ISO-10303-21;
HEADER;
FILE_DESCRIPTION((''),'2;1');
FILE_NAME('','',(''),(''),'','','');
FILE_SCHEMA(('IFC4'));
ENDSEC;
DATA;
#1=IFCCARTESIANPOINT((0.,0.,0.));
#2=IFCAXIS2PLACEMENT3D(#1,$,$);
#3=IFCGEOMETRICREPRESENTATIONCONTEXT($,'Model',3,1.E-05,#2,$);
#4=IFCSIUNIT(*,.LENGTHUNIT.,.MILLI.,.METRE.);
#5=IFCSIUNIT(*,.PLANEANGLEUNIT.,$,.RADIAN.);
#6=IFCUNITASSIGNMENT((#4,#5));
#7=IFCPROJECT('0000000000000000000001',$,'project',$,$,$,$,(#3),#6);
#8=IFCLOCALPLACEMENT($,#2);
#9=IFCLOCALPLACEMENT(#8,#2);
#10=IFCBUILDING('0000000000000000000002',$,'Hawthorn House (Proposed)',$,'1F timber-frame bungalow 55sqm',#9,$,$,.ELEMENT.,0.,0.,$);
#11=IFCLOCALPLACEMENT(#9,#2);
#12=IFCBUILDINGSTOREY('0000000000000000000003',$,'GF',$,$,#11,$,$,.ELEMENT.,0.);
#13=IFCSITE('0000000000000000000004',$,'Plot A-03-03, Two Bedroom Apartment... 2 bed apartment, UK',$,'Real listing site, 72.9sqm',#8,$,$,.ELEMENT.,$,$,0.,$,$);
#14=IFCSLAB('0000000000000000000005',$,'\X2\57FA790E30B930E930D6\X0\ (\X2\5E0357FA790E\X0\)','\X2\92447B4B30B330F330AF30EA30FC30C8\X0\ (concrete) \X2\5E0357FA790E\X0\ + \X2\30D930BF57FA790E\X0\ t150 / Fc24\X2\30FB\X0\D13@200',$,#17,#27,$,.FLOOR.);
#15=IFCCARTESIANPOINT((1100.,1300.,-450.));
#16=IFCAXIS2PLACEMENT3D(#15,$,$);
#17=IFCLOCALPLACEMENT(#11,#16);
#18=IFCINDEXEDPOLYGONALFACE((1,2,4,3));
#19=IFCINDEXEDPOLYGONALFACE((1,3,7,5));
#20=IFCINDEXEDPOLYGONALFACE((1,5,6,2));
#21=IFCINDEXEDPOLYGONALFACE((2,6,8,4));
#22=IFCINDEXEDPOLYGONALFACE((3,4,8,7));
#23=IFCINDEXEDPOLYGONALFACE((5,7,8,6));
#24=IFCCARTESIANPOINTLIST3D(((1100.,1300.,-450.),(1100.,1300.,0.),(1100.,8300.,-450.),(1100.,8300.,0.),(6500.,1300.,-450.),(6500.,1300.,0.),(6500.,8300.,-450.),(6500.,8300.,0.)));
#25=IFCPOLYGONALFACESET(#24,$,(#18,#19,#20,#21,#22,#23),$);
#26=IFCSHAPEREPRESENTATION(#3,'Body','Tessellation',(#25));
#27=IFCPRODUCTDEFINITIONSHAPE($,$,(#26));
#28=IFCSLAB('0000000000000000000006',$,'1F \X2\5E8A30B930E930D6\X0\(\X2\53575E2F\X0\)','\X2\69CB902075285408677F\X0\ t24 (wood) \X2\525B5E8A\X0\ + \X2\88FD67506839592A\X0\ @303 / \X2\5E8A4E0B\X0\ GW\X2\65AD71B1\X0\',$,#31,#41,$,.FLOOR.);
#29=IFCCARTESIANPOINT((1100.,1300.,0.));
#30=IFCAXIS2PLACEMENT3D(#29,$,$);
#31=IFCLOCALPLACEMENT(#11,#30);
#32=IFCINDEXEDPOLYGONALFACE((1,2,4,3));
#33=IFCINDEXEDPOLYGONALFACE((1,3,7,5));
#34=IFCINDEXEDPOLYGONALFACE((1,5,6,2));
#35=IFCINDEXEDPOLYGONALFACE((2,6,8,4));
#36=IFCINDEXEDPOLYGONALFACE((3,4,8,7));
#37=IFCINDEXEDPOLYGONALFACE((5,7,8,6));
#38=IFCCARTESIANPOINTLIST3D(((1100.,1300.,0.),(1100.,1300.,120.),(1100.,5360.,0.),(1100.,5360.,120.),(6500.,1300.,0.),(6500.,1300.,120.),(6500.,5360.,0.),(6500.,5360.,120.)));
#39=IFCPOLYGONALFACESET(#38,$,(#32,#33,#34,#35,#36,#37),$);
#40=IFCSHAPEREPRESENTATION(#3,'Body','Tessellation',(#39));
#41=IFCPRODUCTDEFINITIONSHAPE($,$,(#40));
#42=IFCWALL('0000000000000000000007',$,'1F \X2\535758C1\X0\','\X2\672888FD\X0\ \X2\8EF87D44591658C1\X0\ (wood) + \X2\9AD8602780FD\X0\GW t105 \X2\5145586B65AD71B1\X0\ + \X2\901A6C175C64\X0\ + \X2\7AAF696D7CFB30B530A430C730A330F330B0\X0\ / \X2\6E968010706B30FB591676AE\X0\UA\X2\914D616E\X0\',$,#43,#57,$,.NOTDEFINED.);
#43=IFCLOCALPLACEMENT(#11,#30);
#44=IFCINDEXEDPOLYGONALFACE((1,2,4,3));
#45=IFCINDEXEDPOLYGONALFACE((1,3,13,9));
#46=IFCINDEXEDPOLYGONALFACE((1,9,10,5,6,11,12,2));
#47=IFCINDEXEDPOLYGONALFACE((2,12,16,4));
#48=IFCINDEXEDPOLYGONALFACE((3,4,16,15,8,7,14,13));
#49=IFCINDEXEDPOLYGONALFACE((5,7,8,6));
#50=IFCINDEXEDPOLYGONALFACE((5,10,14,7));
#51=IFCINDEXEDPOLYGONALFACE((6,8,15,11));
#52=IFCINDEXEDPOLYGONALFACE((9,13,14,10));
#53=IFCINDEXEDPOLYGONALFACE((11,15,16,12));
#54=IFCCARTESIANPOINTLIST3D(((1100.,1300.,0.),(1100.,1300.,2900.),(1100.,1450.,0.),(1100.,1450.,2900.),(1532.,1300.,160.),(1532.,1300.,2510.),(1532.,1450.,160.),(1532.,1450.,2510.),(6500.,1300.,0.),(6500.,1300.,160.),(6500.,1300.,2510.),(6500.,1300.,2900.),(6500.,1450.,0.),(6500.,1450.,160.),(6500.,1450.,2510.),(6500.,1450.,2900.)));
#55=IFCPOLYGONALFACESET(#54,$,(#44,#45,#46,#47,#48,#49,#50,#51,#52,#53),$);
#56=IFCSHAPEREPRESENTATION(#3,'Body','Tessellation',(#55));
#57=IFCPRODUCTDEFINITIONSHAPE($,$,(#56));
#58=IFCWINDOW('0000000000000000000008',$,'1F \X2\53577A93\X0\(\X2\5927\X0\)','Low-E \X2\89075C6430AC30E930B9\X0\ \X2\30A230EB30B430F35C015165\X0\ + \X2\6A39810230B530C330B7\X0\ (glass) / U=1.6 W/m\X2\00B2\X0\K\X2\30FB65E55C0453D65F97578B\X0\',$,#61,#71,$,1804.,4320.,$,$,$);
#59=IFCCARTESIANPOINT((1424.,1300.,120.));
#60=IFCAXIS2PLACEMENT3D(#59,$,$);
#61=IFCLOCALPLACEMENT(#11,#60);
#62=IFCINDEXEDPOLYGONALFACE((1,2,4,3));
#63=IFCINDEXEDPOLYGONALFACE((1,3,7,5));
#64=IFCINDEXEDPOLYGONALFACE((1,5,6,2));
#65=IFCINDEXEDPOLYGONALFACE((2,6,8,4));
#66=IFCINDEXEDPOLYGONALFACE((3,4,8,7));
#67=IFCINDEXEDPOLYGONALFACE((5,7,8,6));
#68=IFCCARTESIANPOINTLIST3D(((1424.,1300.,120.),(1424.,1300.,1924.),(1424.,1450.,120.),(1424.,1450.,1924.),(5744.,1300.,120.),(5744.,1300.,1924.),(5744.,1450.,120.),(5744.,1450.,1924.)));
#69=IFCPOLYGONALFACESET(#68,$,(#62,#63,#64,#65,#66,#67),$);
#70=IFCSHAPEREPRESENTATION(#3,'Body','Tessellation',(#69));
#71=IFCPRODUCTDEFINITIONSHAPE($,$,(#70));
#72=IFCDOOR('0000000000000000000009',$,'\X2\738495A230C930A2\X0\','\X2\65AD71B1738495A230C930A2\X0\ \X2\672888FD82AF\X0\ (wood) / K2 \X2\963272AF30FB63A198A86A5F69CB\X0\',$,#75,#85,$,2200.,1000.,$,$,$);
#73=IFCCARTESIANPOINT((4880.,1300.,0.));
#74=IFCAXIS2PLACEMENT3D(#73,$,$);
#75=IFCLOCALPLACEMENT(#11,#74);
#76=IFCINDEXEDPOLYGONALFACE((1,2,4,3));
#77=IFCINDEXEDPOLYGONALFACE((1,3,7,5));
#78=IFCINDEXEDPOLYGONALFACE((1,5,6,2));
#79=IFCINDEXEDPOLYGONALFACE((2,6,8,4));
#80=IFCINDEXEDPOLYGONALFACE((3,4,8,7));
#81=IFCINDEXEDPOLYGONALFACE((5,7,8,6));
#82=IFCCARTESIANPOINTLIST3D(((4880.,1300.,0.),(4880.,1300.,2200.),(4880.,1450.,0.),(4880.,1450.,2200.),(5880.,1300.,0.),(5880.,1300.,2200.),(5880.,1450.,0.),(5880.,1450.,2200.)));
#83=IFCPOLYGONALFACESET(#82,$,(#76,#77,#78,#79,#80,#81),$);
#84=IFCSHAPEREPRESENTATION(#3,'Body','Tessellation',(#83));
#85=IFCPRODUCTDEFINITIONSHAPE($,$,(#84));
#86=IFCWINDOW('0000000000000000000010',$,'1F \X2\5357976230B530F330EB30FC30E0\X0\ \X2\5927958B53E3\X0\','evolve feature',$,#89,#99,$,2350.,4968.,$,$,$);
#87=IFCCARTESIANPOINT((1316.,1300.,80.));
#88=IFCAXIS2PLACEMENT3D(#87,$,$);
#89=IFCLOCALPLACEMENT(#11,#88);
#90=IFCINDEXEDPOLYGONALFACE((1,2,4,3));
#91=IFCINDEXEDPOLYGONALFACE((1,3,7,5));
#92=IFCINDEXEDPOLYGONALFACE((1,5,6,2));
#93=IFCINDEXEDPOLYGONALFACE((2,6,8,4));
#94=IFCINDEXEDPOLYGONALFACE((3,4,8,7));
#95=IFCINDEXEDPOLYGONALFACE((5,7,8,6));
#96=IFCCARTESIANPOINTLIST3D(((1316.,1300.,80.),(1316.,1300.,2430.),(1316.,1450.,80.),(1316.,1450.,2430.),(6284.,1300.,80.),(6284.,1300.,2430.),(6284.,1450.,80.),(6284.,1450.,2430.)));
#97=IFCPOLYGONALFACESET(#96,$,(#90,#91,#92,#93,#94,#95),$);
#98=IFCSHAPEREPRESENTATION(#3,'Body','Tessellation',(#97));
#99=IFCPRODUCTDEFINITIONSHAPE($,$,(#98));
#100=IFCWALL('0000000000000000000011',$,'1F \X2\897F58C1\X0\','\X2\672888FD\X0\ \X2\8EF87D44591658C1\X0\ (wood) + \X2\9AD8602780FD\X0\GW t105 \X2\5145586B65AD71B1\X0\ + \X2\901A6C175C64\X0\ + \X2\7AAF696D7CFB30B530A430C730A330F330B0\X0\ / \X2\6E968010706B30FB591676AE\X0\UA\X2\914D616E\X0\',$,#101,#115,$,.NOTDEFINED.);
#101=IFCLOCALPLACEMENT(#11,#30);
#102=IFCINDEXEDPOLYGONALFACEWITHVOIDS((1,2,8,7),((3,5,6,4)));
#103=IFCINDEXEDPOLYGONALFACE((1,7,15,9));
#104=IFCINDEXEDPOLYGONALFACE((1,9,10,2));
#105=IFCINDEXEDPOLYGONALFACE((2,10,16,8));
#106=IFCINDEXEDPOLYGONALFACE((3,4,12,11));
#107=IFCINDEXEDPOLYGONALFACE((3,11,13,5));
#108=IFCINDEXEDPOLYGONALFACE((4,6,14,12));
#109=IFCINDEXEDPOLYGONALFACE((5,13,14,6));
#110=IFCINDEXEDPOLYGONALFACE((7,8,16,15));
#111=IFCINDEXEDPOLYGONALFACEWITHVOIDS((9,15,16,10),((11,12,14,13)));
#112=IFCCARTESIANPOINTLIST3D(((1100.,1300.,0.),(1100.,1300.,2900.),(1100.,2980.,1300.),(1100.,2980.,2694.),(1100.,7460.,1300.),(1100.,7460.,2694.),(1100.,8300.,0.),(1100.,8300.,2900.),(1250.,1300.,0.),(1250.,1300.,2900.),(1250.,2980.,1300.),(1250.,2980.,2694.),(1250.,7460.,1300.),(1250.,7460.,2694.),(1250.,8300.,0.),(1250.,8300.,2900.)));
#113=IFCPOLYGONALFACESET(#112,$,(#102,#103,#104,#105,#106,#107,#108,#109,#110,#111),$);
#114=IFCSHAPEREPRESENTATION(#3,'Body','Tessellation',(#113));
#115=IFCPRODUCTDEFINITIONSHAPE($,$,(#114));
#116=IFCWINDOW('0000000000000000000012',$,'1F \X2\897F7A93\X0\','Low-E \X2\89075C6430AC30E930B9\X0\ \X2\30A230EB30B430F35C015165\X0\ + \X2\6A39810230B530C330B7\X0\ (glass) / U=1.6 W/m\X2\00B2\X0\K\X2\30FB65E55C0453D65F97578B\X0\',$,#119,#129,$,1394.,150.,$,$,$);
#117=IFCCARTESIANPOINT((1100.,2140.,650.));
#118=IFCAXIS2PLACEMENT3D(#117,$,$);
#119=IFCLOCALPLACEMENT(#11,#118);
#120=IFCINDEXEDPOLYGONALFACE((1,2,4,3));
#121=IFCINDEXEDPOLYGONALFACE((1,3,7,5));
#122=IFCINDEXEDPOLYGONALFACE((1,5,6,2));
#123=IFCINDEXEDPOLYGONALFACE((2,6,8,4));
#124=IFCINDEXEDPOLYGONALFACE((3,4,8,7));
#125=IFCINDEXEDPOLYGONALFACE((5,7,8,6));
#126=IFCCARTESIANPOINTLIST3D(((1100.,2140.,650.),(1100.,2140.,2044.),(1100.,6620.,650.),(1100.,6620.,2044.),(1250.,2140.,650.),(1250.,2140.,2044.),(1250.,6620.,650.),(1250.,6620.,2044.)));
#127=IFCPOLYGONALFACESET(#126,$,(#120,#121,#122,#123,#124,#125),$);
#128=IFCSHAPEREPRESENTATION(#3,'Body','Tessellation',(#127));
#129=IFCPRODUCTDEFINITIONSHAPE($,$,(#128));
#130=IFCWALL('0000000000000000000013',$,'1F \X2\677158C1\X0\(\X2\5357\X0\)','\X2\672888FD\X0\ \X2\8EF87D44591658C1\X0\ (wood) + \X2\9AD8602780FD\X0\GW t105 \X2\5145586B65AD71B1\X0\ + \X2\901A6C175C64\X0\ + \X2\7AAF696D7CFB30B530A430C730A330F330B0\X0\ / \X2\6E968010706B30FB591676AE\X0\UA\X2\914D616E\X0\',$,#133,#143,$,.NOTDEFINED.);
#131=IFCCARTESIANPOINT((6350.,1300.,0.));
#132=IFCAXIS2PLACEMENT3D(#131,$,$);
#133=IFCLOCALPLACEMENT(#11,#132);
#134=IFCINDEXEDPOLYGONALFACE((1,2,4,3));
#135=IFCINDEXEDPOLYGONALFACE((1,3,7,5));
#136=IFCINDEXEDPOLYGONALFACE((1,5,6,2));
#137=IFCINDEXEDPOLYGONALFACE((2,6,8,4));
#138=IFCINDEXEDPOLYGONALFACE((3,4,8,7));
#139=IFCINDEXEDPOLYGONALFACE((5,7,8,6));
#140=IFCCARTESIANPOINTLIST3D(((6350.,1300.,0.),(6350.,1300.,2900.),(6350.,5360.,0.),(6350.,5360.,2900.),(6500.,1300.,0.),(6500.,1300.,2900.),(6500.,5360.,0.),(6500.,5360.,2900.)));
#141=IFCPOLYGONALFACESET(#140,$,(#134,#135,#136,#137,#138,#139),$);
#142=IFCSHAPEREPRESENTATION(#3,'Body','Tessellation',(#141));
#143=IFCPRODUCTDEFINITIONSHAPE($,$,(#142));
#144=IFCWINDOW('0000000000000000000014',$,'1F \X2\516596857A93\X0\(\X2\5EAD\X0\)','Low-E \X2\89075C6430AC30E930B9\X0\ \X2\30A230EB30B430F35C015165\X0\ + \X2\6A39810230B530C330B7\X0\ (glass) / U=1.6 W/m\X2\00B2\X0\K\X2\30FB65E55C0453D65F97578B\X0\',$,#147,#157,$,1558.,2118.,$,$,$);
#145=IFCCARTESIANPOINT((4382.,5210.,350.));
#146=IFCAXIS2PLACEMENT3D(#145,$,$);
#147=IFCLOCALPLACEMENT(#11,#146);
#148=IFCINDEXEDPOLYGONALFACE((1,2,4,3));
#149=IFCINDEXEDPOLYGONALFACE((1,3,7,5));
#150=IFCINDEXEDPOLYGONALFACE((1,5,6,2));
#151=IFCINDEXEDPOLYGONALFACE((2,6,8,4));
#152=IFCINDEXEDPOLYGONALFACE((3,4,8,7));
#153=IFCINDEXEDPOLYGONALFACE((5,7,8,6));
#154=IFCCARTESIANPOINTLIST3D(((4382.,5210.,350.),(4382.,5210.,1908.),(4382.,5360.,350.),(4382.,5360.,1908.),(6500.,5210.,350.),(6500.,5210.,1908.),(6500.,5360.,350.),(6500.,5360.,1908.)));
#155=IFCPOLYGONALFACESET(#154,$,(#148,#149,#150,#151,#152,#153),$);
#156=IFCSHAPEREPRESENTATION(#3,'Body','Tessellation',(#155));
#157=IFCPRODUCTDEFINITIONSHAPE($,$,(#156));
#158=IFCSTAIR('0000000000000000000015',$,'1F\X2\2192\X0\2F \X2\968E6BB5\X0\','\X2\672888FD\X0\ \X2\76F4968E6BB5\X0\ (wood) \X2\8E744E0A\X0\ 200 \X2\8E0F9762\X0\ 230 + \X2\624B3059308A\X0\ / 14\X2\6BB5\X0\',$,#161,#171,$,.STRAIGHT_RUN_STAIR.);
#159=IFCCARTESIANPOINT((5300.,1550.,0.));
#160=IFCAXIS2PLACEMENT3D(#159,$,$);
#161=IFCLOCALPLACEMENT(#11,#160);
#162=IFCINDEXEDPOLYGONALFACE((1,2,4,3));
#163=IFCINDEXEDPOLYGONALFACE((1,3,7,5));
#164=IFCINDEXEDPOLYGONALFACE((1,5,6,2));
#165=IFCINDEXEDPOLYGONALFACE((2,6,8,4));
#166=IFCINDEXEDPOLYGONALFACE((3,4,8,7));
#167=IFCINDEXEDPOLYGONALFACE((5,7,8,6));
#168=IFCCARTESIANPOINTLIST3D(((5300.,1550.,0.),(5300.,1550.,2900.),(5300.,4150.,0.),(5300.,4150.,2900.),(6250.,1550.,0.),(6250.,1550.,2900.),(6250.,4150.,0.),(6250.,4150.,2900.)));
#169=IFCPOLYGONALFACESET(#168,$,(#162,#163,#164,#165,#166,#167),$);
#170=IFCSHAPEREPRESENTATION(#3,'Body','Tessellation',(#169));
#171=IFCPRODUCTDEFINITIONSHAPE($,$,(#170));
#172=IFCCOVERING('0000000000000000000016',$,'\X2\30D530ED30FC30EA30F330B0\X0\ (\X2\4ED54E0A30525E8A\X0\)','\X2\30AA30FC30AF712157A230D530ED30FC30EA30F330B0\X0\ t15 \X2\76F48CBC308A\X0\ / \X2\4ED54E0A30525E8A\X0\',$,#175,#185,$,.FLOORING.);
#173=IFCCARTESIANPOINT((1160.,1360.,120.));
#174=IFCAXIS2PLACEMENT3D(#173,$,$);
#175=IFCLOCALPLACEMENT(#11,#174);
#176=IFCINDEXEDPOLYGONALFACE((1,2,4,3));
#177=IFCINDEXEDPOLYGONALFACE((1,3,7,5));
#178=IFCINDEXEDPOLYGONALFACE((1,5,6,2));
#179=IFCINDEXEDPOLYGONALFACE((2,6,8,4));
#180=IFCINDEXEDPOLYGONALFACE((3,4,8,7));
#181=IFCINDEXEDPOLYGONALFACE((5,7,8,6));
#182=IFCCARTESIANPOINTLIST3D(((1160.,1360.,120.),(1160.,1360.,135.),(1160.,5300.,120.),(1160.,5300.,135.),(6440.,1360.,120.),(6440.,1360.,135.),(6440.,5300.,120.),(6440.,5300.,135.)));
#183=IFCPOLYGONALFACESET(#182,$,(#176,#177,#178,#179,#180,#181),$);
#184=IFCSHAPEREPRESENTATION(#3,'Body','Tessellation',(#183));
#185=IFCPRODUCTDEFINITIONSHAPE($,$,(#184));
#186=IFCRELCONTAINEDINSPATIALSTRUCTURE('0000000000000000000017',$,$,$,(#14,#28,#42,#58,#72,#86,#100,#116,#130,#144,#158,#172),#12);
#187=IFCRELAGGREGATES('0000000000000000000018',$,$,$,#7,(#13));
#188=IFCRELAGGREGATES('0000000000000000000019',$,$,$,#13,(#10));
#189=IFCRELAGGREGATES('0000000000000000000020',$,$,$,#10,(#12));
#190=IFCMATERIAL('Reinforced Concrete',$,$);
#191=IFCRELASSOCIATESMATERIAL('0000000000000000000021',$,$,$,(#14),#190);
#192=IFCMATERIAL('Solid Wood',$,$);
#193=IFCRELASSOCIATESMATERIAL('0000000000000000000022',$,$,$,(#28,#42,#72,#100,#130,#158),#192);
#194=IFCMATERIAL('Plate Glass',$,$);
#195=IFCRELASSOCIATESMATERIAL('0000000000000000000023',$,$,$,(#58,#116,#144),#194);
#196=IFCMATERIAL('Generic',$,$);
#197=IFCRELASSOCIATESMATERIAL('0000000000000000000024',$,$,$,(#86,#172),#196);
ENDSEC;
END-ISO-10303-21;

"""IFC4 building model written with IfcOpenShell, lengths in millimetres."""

from ifc_helpers import new_model, si_unit, frame, frame_2d, origin, place, context, project, spatial, rectangle, extrude, material, element, fill, save


model = new_model("IFC4")

# Units and contexts
model_context = context("Model", 3, precision=1e-05, world=origin())
ifc_project = project(units=[si_unit("LENGTHUNIT", "METRE", prefix="MILLI"), si_unit("PLANEANGLEUNIT", "RADIAN")], contexts=[model_context])

# Site, building, storey
site_placement = place(None, origin())
site = spatial("IfcSite", under=ifc_project, at=site_placement, Name="Plot A-03-03, Two Bedroom Apartment... 2 bed apartment, UK", ObjectType="Real listing site, 72.9sqm", CompositionType="ELEMENT", RefElevation=0.0)
building_placement = place(site_placement, origin())
building = spatial("IfcBuilding", under=site, at=building_placement, Name="Hawthorn House (Proposed)", ObjectType="1F timber-frame bungalow 55sqm", CompositionType="ELEMENT", ElevationOfRefHeight=0.0, ElevationOfTerrain=0.0)
storey_placement = place(building_placement, origin())
storey = spatial("IfcBuildingStorey", under=building, at=storey_placement, Name="GF", CompositionType="ELEMENT", Elevation=0.0)

# Slabs
ifc_material_1 = material(Name="Reinforced Concrete")
slab_1_placement = place(storey_placement, frame((1100.0, 1300.0, -450.0)))
element("IfcSlab", 1, at=slab_1_placement, inside=storey, material=ifc_material_1, Name="基礎スラブ (布基礎)", Description="鉄筋コンクリート (concrete) 布基礎 + ベタ基礎 t150 / Fc24・D13@200", PredefinedType="FLOOR", context=model_context, shape_type="SweptSolid", body=[
    extrude(rectangle(XDim=5400.0, YDim=7000.0, at=frame_2d((2700.0, 3500.0))), frame((1100.0, 1300.0, -450.0)), (0.0, 0.0, 1.0), 450.0),
])
ifc_material_2 = material(Name="Solid Wood")
slab_2_placement = place(storey_placement, frame((1100.0, 1300.0, 0.0)))
element("IfcSlab", 2, at=slab_2_placement, inside=storey, material=ifc_material_2, Name="1F 床スラブ(南帯)", Description="構造用合板 t24 (wood) 剛床 + 製材根太 @303 / 床下 GW断熱", PredefinedType="FLOOR", context=model_context, shape_type="SweptSolid", body=[
    extrude(rectangle(XDim=5400.0, YDim=4060.0, at=frame_2d((2700.0, 2030.0))), frame((1100.0, 1300.0, 0.0)), (0.0, 0.0, 1.0), 120.0),
])

# Wall, openings, windows, door
wall_1_placement = place(storey_placement, frame((1100.0, 1300.0, 0.0)))
wall_1 = element("IfcWall", 3, at=wall_1_placement, inside=storey, material=ifc_material_2, Name="1F 南壁", Description="木製 軸組外壁 (wood) + 高性能GW t105 充填断熱 + 通気層 + 窯業系サイディング / 準耐火・外皮UA配慮", PredefinedType="NOTDEFINED", context=model_context, shape_type="SweptSolid", body=[
    extrude(rectangle(XDim=5400.0, YDim=150.0, at=frame_2d((2700.0, 75.0))), frame((1100.0, 1300.0, 0.0)), (0.0, 0.0, 1.0), 2900.0),
])
opening_1_placement = place(storey_placement, frame((1424.0, 1300.0, 120.0)))
opening_1 = element("IfcOpeningElement", 4, at=opening_1_placement, cuts=wall_1, PredefinedType="NOTDEFINED", context=model_context, shape_type="SweptSolid", body=[
    extrude(rectangle(XDim=4320.0, YDim=150.0, at=frame_2d((2160.0, 75.0))), frame((1424.0, 1300.0, 120.0)), (0.0, 0.0, 1.0), 1804.0),
])
opening_2_placement = place(storey_placement, frame((4880.0, 1300.0, 0.0)))
opening_2 = element("IfcOpeningElement", 5, at=opening_2_placement, cuts=wall_1, PredefinedType="NOTDEFINED", context=model_context, shape_type="SweptSolid", body=[
    extrude(rectangle(XDim=1000.0, YDim=150.0, at=frame_2d((500.0, 75.0))), frame((4880.0, 1300.0, 0.0)), (0.0, 0.0, 1.0), 2200.0),
])
opening_3_placement = place(storey_placement, frame((1316.0, 1300.0, 80.0)))
opening_3 = element("IfcOpeningElement", 6, at=opening_3_placement, cuts=wall_1, PredefinedType="NOTDEFINED", context=model_context, shape_type="SweptSolid", body=[
    extrude(rectangle(XDim=4968.0, YDim=150.0, at=frame_2d((2484.0, 75.0))), frame((1316.0, 1300.0, 80.0)), (0.0, 0.0, 1.0), 2350.0),
])
ifc_material_3 = material(Name="Plate Glass")
window_1_placement = place(storey_placement, frame((1424.0, 1300.0, 120.0)))
window_1 = element("IfcWindow", 7, at=window_1_placement, inside=storey, material=ifc_material_3, Name="1F 南窓(大)", Description="Low-E 複層ガラス アルゴン封入 + 樹脂サッシ (glass) / U=1.6 W/m²K・日射取得型", OverallHeight=1804.0, OverallWidth=4320.0, context=model_context, shape_type="SweptSolid", body=[
    extrude(rectangle(XDim=4320.0, YDim=150.0, at=frame_2d((2160.0, 75.0))), frame((1424.0, 1300.0, 120.0)), (0.0, 0.0, 1.0), 1804.0),
])
fill(opening_1, window_1)
door_1_placement = place(storey_placement, frame((4880.0, 1300.0, 0.0)))
door_1 = element("IfcDoor", 8, at=door_1_placement, inside=storey, material=ifc_material_2, Name="玄関ドア", Description="断熱玄関ドア 木製芯 (wood) / K2 防犯・採風機構", OverallHeight=2200.0, OverallWidth=1000.0, context=model_context, shape_type="SweptSolid", body=[
    extrude(rectangle(XDim=1000.0, YDim=150.0, at=frame_2d((500.0, 75.0))), frame((4880.0, 1300.0, 0.0)), (0.0, 0.0, 1.0), 2200.0),
])
fill(opening_2, door_1)
ifc_material_4 = material(Name="Generic")
window_2_placement = place(storey_placement, frame((1316.0, 1300.0, 80.0)))
window_2 = element("IfcWindow", 9, at=window_2_placement, inside=storey, material=ifc_material_4, Name="1F 南面サンルーム 大開口", Description="evolve feature", OverallHeight=2350.0, OverallWidth=4968.0, context=model_context, shape_type="SweptSolid", body=[
    extrude(rectangle(XDim=4968.0, YDim=150.0, at=frame_2d((2484.0, 75.0))), frame((1316.0, 1300.0, 80.0)), (0.0, 0.0, 1.0), 2350.0),
])
fill(opening_3, window_2)

# Walls, openings, windows
wall_2_placement = place(storey_placement, frame((1100.0, 1300.0, 0.0)))
wall_2 = element("IfcWall", 10, at=wall_2_placement, inside=storey, material=ifc_material_2, Name="1F 西壁", Description="木製 軸組外壁 (wood) + 高性能GW t105 充填断熱 + 通気層 + 窯業系サイディング / 準耐火・外皮UA配慮", PredefinedType="NOTDEFINED", context=model_context, shape_type="SweptSolid", body=[
    extrude(rectangle(XDim=150.0, YDim=7000.0, at=frame_2d((75.0, 3500.0))), frame((1100.0, 1300.0, 0.0)), (0.0, 0.0, 1.0), 2900.0),
])
opening_4_placement = place(storey_placement, frame((1100.0, 2140.0, 650.0)))
opening_4 = element("IfcOpeningElement", 11, at=opening_4_placement, cuts=wall_2, PredefinedType="NOTDEFINED", context=model_context, shape_type="SweptSolid", body=[
    extrude(rectangle(XDim=150.0, YDim=4480.0, at=frame_2d((75.0, 2240.0))), frame((1100.0, 2140.0, 650.0)), (0.0, 0.0, 1.0), 1394.0),
])
window_3_placement = place(storey_placement, frame((1100.0, 2140.0, 650.0)))
window_3 = element("IfcWindow", 12, at=window_3_placement, inside=storey, material=ifc_material_3, Name="1F 西窓", Description="Low-E 複層ガラス アルゴン封入 + 樹脂サッシ (glass) / U=1.6 W/m²K・日射取得型", OverallHeight=1394.0, OverallWidth=150.0, context=model_context, shape_type="SweptSolid", body=[
    extrude(rectangle(XDim=150.0, YDim=4480.0, at=frame_2d((75.0, 2240.0))), frame((1100.0, 2140.0, 650.0)), (0.0, 0.0, 1.0), 1394.0),
])
fill(opening_4, window_3)
wall_3_placement = place(storey_placement, frame((6350.0, 1300.0, 0.0)))
wall_3 = element("IfcWall", 13, at=wall_3_placement, inside=storey, material=ifc_material_2, Name="1F 東壁(南)", Description="木製 軸組外壁 (wood) + 高性能GW t105 充填断熱 + 通気層 + 窯業系サイディング / 準耐火・外皮UA配慮", PredefinedType="NOTDEFINED", context=model_context, shape_type="SweptSolid", body=[
    extrude(rectangle(XDim=150.0, YDim=4060.0, at=frame_2d((75.0, 2030.0))), frame((6350.0, 1300.0, 0.0)), (0.0, 0.0, 1.0), 2900.0),
])
opening_5_placement = place(storey_placement, frame((4382.0, 5210.0, 350.0)))
opening_5 = element("IfcOpeningElement", 14, at=opening_5_placement, cuts=wall_3, PredefinedType="NOTDEFINED", context=model_context, shape_type="SweptSolid", body=[
    extrude(rectangle(XDim=2118.0, YDim=150.0, at=frame_2d((1059.0, 75.0))), frame((4382.0, 5210.0, 350.0)), (0.0, 0.0, 1.0), 1558.0),
])
window_4_placement = place(storey_placement, frame((4382.0, 5210.0, 350.0)))
window_4 = element("IfcWindow", 15, at=window_4_placement, inside=storey, material=ifc_material_3, Name="1F 入隅窓(庭)", Description="Low-E 複層ガラス アルゴン封入 + 樹脂サッシ (glass) / U=1.6 W/m²K・日射取得型", OverallHeight=1558.0, OverallWidth=2118.0, context=model_context, shape_type="SweptSolid", body=[
    extrude(rectangle(XDim=2118.0, YDim=150.0, at=frame_2d((1059.0, 75.0))), frame((4382.0, 5210.0, 350.0)), (0.0, 0.0, 1.0), 1558.0),
])
fill(opening_5, window_4)

# Stair
stair_placement = place(storey_placement, frame((5300.0, 1550.0, 0.0)))
element("IfcStair", 16, at=stair_placement, inside=storey, material=ifc_material_2, Name="1F→2F 階段", Description="木製 直階段 (wood) 蹴上 200 踏面 230 + 手すり / 14段", PredefinedType="STRAIGHT_RUN_STAIR", context=model_context, shape_type="SweptSolid", body=[
    extrude(rectangle(XDim=950.0, YDim=2600.0, at=frame_2d((475.0, 1300.0))), frame((5300.0, 1550.0, 0.0)), (0.0, 0.0, 1.0), 2900.0),
])

# Covering
covering_placement = place(storey_placement, frame((1160.0, 1360.0, 120.0)))
element("IfcCovering", 17, at=covering_placement, inside=storey, material=ifc_material_4, Name="フローリング (仕上げ床)", Description="オーク無垢フローリング t15 直貼り / 仕上げ床", PredefinedType="FLOORING", context=model_context, shape_type="SweptSolid", body=[
    extrude(rectangle(XDim=5280.0, YDim=3940.0, at=frame_2d((2640.0, 1970.0))), frame((1160.0, 1360.0, 120.0)), (0.0, 0.0, 1.0), 15.0),
])

save(model, "model.ifc")
